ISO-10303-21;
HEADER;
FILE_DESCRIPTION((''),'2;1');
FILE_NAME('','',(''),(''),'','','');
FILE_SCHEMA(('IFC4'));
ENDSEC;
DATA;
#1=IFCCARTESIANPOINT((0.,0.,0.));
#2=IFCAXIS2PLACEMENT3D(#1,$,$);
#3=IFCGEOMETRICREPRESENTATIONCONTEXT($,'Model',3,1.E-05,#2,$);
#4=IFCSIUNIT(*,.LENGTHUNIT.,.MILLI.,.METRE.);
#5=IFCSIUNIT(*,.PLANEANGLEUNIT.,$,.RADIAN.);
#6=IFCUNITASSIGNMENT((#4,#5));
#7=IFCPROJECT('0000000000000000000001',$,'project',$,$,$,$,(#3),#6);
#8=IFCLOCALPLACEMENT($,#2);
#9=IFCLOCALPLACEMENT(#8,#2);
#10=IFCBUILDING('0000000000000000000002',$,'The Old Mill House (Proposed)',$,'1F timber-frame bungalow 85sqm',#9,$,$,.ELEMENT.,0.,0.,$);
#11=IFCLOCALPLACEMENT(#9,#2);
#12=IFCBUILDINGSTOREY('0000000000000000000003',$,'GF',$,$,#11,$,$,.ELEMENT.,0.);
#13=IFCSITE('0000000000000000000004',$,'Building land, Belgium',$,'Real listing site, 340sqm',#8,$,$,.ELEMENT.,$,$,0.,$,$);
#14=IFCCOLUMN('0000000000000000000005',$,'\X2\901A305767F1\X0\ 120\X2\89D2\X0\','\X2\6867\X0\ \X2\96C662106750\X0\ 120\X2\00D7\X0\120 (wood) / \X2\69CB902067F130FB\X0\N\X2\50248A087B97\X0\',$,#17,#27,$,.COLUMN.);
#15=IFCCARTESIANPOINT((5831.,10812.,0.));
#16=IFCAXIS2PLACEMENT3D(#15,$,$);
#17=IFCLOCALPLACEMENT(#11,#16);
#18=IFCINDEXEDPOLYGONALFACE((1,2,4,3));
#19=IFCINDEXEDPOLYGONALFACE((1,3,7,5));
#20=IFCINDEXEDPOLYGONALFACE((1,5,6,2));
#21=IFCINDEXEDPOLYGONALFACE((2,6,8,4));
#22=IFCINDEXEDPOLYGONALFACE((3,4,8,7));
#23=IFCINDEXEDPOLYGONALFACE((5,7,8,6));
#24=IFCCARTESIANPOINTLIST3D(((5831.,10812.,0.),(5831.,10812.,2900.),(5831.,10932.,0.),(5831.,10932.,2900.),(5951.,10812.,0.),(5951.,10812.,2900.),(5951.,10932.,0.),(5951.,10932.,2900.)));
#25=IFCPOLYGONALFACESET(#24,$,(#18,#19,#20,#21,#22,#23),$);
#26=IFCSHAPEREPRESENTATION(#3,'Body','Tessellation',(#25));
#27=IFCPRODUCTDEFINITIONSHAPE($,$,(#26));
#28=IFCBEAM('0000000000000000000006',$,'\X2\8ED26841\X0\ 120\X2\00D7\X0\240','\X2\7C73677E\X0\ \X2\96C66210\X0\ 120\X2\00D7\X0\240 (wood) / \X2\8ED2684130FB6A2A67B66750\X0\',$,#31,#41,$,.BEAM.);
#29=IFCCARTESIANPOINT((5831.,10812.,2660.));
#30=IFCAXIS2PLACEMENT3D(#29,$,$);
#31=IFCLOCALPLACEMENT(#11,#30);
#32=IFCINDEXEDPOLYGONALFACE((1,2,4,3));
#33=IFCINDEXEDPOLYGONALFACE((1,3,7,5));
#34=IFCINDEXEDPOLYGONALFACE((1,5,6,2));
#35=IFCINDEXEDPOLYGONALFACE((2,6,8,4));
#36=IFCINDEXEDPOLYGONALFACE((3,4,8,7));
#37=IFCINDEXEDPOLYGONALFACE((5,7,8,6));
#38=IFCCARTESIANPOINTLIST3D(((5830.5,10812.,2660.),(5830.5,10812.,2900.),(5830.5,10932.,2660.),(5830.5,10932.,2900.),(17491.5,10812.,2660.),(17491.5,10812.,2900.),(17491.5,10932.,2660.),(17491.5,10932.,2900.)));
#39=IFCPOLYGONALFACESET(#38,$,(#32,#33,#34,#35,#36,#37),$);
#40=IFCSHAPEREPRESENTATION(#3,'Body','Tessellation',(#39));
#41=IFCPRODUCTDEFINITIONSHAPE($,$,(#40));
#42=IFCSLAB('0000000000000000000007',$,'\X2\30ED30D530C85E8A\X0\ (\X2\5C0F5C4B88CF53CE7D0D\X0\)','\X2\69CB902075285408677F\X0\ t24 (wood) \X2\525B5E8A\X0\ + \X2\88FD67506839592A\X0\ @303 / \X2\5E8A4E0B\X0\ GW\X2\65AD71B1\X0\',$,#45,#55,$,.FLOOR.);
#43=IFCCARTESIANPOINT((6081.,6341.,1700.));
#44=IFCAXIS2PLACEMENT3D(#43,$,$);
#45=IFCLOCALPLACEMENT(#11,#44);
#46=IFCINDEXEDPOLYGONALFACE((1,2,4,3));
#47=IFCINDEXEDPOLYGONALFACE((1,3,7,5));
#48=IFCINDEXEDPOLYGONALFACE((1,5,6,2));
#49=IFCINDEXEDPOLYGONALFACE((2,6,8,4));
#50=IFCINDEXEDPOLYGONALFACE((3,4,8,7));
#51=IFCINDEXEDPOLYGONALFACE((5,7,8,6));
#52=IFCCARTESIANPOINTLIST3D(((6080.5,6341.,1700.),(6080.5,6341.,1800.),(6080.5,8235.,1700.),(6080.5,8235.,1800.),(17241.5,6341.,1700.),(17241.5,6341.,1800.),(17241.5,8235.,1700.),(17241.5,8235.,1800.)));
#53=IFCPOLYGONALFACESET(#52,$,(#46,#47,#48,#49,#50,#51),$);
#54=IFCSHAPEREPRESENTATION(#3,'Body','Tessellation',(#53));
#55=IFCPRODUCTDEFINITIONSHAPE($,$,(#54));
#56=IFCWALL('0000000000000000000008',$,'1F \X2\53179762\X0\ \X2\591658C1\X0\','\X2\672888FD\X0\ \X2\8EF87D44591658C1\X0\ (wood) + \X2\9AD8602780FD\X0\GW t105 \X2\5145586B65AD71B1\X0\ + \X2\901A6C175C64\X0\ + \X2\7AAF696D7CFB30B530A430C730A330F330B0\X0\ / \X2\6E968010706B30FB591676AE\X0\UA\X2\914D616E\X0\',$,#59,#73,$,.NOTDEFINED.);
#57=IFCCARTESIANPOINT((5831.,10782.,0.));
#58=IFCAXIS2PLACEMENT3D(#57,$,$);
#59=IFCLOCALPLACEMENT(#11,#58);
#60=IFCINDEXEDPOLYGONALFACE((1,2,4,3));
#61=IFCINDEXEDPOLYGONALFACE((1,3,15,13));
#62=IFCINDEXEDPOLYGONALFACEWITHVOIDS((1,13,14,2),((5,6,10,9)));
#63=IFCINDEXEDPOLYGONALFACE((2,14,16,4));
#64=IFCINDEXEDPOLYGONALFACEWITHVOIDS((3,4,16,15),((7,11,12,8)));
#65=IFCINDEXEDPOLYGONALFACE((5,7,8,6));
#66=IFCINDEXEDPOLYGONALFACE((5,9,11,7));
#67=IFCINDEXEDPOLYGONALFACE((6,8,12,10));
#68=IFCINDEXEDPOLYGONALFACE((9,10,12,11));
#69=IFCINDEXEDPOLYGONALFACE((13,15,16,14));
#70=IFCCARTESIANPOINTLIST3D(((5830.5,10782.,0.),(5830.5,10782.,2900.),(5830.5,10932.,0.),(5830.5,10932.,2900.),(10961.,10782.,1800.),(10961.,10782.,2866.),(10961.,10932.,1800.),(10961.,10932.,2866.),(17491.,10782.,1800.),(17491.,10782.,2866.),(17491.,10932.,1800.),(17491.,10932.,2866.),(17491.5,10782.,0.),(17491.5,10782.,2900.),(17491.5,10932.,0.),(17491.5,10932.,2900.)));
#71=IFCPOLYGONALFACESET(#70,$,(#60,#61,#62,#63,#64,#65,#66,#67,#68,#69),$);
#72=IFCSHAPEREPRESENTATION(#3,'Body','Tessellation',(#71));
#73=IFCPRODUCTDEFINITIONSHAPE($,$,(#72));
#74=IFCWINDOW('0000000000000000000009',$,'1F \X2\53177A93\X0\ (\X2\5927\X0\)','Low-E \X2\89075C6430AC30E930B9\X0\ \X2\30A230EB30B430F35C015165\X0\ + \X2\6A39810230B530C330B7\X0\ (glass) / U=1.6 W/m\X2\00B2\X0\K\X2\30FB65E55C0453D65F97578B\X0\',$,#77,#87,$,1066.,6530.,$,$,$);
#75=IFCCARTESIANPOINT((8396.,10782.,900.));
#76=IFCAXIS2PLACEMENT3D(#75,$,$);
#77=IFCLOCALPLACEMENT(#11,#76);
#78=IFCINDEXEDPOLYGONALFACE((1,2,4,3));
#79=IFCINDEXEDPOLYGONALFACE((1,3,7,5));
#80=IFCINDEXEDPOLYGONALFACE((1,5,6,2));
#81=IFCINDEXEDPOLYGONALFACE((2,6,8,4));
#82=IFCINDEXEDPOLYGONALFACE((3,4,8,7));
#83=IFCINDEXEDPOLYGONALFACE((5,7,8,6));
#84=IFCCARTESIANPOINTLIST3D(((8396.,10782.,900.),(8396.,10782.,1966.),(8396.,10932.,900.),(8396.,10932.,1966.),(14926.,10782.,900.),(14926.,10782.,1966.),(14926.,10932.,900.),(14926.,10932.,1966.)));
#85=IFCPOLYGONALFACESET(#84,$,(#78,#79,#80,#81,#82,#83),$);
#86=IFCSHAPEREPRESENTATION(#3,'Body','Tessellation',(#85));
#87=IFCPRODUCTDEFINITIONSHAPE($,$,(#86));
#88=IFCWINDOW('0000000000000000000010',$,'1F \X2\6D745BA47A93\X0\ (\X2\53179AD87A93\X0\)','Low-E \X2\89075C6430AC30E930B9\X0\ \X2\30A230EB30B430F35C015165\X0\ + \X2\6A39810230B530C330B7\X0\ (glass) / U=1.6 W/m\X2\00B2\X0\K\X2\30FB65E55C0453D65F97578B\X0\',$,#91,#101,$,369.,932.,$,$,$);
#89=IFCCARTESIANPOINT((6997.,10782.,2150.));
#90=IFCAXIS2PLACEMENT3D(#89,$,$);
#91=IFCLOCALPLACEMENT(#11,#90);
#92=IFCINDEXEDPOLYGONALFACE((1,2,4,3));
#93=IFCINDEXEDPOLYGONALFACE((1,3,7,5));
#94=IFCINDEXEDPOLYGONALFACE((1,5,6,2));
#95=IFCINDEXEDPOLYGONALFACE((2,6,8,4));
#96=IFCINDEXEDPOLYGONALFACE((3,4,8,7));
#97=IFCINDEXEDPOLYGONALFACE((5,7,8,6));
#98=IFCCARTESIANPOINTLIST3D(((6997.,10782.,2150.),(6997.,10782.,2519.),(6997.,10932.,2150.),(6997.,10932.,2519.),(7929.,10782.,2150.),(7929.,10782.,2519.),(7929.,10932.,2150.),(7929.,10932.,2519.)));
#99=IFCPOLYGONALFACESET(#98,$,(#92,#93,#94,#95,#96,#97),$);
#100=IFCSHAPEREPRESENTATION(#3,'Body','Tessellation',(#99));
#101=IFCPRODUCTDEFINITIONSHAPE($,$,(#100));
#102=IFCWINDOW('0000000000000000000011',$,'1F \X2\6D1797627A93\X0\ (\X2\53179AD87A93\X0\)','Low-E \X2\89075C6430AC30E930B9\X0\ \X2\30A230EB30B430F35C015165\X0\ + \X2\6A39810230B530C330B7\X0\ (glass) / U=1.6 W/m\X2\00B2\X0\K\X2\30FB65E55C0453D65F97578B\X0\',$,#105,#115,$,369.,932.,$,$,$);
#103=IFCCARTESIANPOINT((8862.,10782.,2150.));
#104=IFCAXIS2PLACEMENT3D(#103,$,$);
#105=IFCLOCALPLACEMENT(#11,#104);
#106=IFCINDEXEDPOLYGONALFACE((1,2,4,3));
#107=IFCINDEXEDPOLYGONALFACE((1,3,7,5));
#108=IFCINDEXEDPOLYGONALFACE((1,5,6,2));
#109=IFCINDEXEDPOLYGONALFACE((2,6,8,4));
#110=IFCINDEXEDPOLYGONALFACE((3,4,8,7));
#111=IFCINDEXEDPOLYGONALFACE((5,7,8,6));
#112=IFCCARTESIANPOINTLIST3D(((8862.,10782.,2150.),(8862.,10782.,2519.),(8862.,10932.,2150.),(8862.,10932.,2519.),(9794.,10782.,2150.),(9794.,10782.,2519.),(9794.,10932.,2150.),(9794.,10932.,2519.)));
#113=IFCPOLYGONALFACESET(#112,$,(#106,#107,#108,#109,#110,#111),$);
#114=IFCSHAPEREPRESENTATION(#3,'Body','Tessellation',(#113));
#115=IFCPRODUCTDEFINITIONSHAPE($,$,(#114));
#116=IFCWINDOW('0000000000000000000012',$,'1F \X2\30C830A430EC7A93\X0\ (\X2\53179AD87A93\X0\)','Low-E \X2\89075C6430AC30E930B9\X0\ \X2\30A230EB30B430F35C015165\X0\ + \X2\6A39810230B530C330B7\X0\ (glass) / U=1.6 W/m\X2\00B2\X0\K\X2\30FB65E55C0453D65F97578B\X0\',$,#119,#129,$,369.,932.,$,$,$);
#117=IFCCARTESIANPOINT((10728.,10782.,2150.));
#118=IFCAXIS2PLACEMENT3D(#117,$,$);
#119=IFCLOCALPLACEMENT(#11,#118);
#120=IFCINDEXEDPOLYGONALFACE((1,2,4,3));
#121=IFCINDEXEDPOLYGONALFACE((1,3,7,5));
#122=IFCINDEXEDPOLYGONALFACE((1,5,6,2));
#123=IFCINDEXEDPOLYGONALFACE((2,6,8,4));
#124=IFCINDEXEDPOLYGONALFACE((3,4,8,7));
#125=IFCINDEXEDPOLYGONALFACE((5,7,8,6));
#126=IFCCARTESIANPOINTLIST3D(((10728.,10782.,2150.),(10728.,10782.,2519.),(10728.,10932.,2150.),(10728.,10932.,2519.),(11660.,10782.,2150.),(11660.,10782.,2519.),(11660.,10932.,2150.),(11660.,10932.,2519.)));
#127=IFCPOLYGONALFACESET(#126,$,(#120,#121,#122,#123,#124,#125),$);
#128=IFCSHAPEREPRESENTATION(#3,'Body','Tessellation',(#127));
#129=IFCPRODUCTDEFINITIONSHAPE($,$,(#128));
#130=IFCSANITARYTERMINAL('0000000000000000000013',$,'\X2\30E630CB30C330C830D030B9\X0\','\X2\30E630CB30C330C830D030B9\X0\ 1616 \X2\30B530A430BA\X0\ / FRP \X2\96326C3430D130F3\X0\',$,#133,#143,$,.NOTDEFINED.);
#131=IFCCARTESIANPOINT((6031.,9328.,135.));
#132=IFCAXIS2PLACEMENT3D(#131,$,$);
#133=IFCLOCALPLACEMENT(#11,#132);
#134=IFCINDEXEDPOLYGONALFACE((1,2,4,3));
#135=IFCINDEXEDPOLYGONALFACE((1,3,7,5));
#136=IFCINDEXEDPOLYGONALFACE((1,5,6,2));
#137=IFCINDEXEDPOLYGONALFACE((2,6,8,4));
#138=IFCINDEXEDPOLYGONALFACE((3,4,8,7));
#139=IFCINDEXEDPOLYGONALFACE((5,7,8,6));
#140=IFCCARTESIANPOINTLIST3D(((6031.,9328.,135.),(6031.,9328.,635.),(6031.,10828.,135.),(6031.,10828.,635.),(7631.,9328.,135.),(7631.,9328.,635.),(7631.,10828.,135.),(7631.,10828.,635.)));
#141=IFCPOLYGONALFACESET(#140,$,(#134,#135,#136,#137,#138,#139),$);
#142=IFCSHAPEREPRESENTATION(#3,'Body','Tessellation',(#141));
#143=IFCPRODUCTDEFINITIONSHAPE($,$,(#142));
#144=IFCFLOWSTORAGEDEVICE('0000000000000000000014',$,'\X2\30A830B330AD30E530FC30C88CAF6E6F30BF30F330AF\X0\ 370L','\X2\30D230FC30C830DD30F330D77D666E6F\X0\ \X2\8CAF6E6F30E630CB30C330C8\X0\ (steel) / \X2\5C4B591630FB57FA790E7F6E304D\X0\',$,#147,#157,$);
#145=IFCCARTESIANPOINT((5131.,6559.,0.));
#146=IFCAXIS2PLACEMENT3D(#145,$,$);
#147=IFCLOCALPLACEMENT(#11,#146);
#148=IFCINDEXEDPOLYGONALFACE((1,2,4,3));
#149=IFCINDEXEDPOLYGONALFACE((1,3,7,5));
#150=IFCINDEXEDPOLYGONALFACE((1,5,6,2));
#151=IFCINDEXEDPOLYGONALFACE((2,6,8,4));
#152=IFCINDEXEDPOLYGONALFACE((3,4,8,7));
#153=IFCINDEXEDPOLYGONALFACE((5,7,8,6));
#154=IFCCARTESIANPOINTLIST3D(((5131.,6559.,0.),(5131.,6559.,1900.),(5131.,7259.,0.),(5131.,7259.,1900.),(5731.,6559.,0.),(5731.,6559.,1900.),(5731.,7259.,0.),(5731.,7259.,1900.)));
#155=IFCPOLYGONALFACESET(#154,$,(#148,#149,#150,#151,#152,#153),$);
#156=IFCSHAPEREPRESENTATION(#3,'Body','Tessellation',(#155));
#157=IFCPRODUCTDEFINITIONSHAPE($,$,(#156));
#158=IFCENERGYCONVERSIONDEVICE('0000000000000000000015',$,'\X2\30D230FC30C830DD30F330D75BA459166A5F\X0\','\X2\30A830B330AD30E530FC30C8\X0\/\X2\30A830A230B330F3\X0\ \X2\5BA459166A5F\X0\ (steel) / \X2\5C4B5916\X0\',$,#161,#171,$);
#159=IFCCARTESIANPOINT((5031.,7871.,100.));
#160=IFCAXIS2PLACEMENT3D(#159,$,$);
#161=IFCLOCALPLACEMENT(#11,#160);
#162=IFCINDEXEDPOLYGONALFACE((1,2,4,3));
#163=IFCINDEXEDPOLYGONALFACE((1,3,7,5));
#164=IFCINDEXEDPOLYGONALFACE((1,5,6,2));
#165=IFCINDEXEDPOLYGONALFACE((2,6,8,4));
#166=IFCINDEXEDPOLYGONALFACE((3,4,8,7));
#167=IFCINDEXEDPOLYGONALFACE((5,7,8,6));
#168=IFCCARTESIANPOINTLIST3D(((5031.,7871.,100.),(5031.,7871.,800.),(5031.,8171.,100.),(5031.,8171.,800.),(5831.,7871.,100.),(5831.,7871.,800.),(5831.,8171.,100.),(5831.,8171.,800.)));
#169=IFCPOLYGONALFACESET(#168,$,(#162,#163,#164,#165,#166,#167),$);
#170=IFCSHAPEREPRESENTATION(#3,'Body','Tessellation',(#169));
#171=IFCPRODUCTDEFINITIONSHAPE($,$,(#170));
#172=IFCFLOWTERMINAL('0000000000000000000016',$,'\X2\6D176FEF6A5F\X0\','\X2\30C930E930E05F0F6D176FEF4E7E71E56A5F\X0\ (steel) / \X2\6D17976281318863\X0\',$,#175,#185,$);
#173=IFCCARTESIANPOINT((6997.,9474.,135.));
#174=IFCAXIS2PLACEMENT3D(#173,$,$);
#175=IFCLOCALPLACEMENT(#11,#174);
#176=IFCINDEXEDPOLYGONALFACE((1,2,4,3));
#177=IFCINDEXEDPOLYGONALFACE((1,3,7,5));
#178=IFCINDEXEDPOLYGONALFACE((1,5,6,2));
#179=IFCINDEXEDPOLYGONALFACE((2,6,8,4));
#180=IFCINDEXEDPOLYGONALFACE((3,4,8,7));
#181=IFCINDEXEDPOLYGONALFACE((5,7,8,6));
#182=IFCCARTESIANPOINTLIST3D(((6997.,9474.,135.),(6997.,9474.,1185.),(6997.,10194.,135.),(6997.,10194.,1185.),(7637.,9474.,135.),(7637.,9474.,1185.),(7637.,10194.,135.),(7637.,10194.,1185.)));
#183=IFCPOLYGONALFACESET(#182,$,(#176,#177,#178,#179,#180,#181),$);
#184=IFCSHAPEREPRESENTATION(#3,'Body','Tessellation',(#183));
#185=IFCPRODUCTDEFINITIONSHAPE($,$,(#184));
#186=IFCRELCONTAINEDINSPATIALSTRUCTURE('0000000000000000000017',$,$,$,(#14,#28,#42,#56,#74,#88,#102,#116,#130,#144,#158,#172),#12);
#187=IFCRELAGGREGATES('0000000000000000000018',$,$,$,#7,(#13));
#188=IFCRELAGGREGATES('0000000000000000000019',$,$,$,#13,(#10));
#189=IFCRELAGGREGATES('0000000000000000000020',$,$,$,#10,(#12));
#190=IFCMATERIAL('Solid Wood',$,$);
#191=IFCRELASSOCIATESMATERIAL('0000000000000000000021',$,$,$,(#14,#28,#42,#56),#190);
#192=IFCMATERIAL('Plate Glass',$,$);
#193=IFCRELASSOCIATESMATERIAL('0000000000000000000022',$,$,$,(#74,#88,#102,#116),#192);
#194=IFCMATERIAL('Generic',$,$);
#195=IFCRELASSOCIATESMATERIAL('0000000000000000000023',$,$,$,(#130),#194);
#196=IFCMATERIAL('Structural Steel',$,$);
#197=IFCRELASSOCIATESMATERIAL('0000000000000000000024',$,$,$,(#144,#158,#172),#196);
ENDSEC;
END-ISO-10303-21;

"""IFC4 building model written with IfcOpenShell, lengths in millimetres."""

from ifc_helpers import new_model, si_unit, frame, frame_2d, origin, place, context, project, spatial, rectangle, extrude, material, element, fill, save


model = new_model("IFC4")

# Units and contexts
model_context = context("Model", 3, precision=1e-05, world=origin())
ifc_project = project(units=[si_unit("LENGTHUNIT", "METRE", prefix="MILLI"), si_unit("PLANEANGLEUNIT", "RADIAN")], contexts=[model_context])

# Site, building, storey
site_placement = place(None, origin())
site = spatial("IfcSite", under=ifc_project, at=site_placement, Name="Building land, Belgium", ObjectType="Real listing site, 340sqm", CompositionType="ELEMENT", RefElevation=0.0)
building_placement = place(site_placement, origin())
building = spatial("IfcBuilding", under=site, at=building_placement, Name="The Old Mill House (Proposed)", ObjectType="1F timber-frame bungalow 85sqm", CompositionType="ELEMENT", ElevationOfRefHeight=0.0, ElevationOfTerrain=0.0)
storey_placement = place(building_placement, origin())
storey = spatial("IfcBuildingStorey", under=building, at=storey_placement, Name="GF", CompositionType="ELEMENT", Elevation=0.0)

# Column
ifc_material_1 = material(Name="Solid Wood")
column_1_placement = place(storey_placement, frame((5831.0, 10812.0, 0.0)))
element("IfcColumn", 1, at=column_1_placement, inside=storey, material=ifc_material_1, Name="通し柱 120角", Description="桧 集成材 120×120 (wood) / 構造柱・N値計算", PredefinedType="COLUMN", context=model_context, shape_type="SweptSolid", body=[
    extrude(rectangle(XDim=120.0, YDim=120.0, at=frame_2d((60.0, 60.0))), frame((5831.0, 10812.0, 0.0)), (0.0, 0.0, 1.0), 2900.0),
])

# Beam
beam_1_placement = place(storey_placement, frame((5831.0, 10812.0, 2660.0)))
element("IfcBeam", 2, at=beam_1_placement, inside=storey, material=ifc_material_1, Name="軒桁 120×240", Description="米松 集成 120×240 (wood) / 軒桁・横架材", PredefinedType="BEAM", context=model_context, shape_type="SweptSolid", body=[
    extrude(rectangle(XDim=11661.0, YDim=120.0, at=frame_2d((5830.0, 60.0))), frame((5831.0, 10812.0, 2660.0)), (0.0, 0.0, 1.0), 240.0),
])

# Slab
slab_placement = place(storey_placement, frame((6081.0, 6341.0, 1700.0)))
element("IfcSlab", 3, at=slab_placement, inside=storey, material=ifc_material_1, Name="ロフト床 (小屋裏収納)", Description="構造用合板 t24 (wood) 剛床 + 製材根太 @303 / 床下 GW断熱", PredefinedType="FLOOR", context=model_context, shape_type="SweptSolid", body=[
    extrude(rectangle(XDim=11161.0, YDim=1894.0, at=frame_2d((5580.0, 947.0))), frame((6081.0, 6341.0, 1700.0)), (0.0, 0.0, 1.0), 100.0),
])

# Wall, openings, windows
wall_1_placement = place(storey_placement, frame((5831.0, 10782.0, 0.0)))
wall_1 = element("IfcWall", 4, at=wall_1_placement, inside=storey, material=ifc_material_1, Name="1F 北面 外壁", Description="木製 軸組外壁 (wood) + 高性能GW t105 充填断熱 + 通気層 + 窯業系サイディング / 準耐火・外皮UA配慮", PredefinedType="NOTDEFINED", context=model_context, shape_type="SweptSolid", body=[
    extrude(rectangle(XDim=11661.0, YDim=150.0, at=frame_2d((5830.0, 75.0))), frame((5831.0, 10782.0, 0.0)), (0.0, 0.0, 1.0), 2900.0),
])
opening_1_placement = place(storey_placement, frame((8396.0, 10782.0, 900.0)))
opening_1 = element("IfcOpeningElement", 5, at=opening_1_placement, cuts=wall_1, PredefinedType="NOTDEFINED", context=model_context, shape_type="SweptSolid", body=[
    extrude(rectangle(XDim=6530.0, YDim=150.0, at=frame_2d((3265.0, 75.0))), frame((8396.0, 10782.0, 900.0)), (0.0, 0.0, 1.0), 1066.0),
])
opening_2_placement = place(storey_placement, frame((6997.0, 10782.0, 2150.0)))
opening_2 = element("IfcOpeningElement", 6, at=opening_2_placement, cuts=wall_1, PredefinedType="NOTDEFINED", context=model_context, shape_type="SweptSolid", body=[
    extrude(rectangle(XDim=932.0, YDim=150.0, at=frame_2d((466.0, 75.0))), frame((6997.0, 10782.0, 2150.0)), (0.0, 0.0, 1.0), 369.0),
])
opening_3_placement = place(storey_placement, frame((8862.0, 10782.0, 2150.0)))
opening_3 = element("IfcOpeningElement", 7, at=opening_3_placement, cuts=wall_1, PredefinedType="NOTDEFINED", context=model_context, shape_type="SweptSolid", body=[
    extrude(rectangle(XDim=932.0, YDim=150.0, at=frame_2d((466.0, 75.0))), frame((8862.0, 10782.0, 2150.0)), (0.0, 0.0, 1.0), 369.0),
])
opening_4_placement = place(storey_placement, frame((10728.0, 10782.0, 2150.0)))
opening_4 = element("IfcOpeningElement", 8, at=opening_4_placement, cuts=wall_1, PredefinedType="NOTDEFINED", context=model_context, shape_type="SweptSolid", body=[
    extrude(rectangle(XDim=932.0, YDim=150.0, at=frame_2d((466.0, 75.0))), frame((10728.0, 10782.0, 2150.0)), (0.0, 0.0, 1.0), 369.0),
])
ifc_material_2 = material(Name="Plate Glass")
window_1_placement = place(storey_placement, frame((8396.0, 10782.0, 900.0)))
window_1 = element("IfcWindow", 9, at=window_1_placement, inside=storey, material=ifc_material_2, Name="1F 北窓 (大)", Description="Low-E 複層ガラス アルゴン封入 + 樹脂サッシ (glass) / U=1.6 W/m²K・日射取得型", OverallHeight=1066.0, OverallWidth=6530.0, context=model_context, shape_type="SweptSolid", body=[
    extrude(rectangle(XDim=6530.0, YDim=150.0, at=frame_2d((3265.0, 75.0))), frame((8396.0, 10782.0, 900.0)), (0.0, 0.0, 1.0), 1066.0),
])
fill(opening_1, window_1)
window_2_placement = place(storey_placement, frame((6997.0, 10782.0, 2150.0)))
window_2 = element("IfcWindow", 10, at=window_2_placement, inside=storey, material=ifc_material_2, Name="1F 浴室窓 (北高窓)", Description="Low-E 複層ガラス アルゴン封入 + 樹脂サッシ (glass) / U=1.6 W/m²K・日射取得型", OverallHeight=369.0, OverallWidth=932.0, context=model_context, shape_type="SweptSolid", body=[
    extrude(rectangle(XDim=932.0, YDim=150.0, at=frame_2d((466.0, 75.0))), frame((6997.0, 10782.0, 2150.0)), (0.0, 0.0, 1.0), 369.0),
])
fill(opening_2, window_2)
window_3_placement = place(storey_placement, frame((8862.0, 10782.0, 2150.0)))
window_3 = element("IfcWindow", 11, at=window_3_placement, inside=storey, material=ifc_material_2, Name="1F 洗面窓 (北高窓)", Description="Low-E 複層ガラス アルゴン封入 + 樹脂サッシ (glass) / U=1.6 W/m²K・日射取得型", OverallHeight=369.0, OverallWidth=932.0, context=model_context, shape_type="SweptSolid", body=[
    extrude(rectangle(XDim=932.0, YDim=150.0, at=frame_2d((466.0, 75.0))), frame((8862.0, 10782.0, 2150.0)), (0.0, 0.0, 1.0), 369.0),
])
fill(opening_3, window_3)
window_4_placement = place(storey_placement, frame((10728.0, 10782.0, 2150.0)))
window_4 = element("IfcWindow", 12, at=window_4_placement, inside=storey, material=ifc_material_2, Name="1F トイレ窓 (北高窓)", Description="Low-E 複層ガラス アルゴン封入 + 樹脂サッシ (glass) / U=1.6 W/m²K・日射取得型", OverallHeight=369.0, OverallWidth=932.0, context=model_context, shape_type="SweptSolid", body=[
    extrude(rectangle(XDim=932.0, YDim=150.0, at=frame_2d((466.0, 75.0))), frame((10728.0, 10782.0, 2150.0)), (0.0, 0.0, 1.0), 369.0),
])
fill(opening_4, window_4)

# Sanitary terminal
ifc_material_3 = material(Name="Generic")
sanitary_terminal_placement = place(storey_placement, frame((6031.0, 9328.0, 135.0)))
element("IfcSanitaryTerminal", 13, at=sanitary_terminal_placement, inside=storey, material=ifc_material_3, Name="ユニットバス", Description="ユニットバス 1616 サイズ / FRP 防水パン", PredefinedType="NOTDEFINED", context=model_context, shape_type="SweptSolid", body=[
    extrude(rectangle(XDim=1600.0, YDim=1500.0, at=frame_2d((800.0, 750.0))), frame((6031.0, 9328.0, 135.0)), (0.0, 0.0, 1.0), 500.0),
])

# Flow storage device
ifc_material_4 = material(Name="Structural Steel")
flow_storage_device_placement = place(storey_placement, frame((5131.0, 6559.0, 0.0)))
element("IfcFlowStorageDevice", 14, at=flow_storage_device_placement, inside=storey, material=ifc_material_4, Name="エコキュート貯湯タンク 370L", Description="ヒートポンプ給湯 貯湯ユニット (steel) / 屋外・基礎置き", context=model_context, shape_type="SweptSolid", body=[
    extrude(rectangle(XDim=600.0, YDim=700.0, at=frame_2d((300.0, 350.0))), frame((5131.0, 6559.0, 0.0)), (0.0, 0.0, 1.0), 1900.0),
])

# Energy conversion device
energy_conversion_device_placement = place(storey_placement, frame((5031.0, 7871.0, 100.0)))
element("IfcEnergyConversionDevice", 15, at=energy_conversion_device_placement, inside=storey, material=ifc_material_4, Name="ヒートポンプ室外機", Description="エコキュート/エアコン 室外機 (steel) / 屋外", context=model_context, shape_type="SweptSolid", body=[
    extrude(rectangle(XDim=800.0, YDim=300.0, at=frame_2d((400.0, 150.0))), frame((5031.0, 7871.0, 100.0)), (0.0, 0.0, 1.0), 700.0),
])

# Flow terminal
flow_terminal_placement = place(storey_placement, frame((6997.0, 9474.0, 135.0)))
element("IfcFlowTerminal", 16, at=flow_terminal_placement, inside=storey, material=ifc_material_4, Name="洗濯機", Description="ドラム式洗濯乾燥機 (steel) / 洗面脱衣", context=model_context, shape_type="SweptSolid", body=[
    extrude(rectangle(XDim=640.0, YDim=720.0, at=frame_2d((320.0, 360.0))), frame((6997.0, 9474.0, 135.0)), (0.0, 0.0, 1.0), 1050.0),
])

save(model, "model.ifc")
